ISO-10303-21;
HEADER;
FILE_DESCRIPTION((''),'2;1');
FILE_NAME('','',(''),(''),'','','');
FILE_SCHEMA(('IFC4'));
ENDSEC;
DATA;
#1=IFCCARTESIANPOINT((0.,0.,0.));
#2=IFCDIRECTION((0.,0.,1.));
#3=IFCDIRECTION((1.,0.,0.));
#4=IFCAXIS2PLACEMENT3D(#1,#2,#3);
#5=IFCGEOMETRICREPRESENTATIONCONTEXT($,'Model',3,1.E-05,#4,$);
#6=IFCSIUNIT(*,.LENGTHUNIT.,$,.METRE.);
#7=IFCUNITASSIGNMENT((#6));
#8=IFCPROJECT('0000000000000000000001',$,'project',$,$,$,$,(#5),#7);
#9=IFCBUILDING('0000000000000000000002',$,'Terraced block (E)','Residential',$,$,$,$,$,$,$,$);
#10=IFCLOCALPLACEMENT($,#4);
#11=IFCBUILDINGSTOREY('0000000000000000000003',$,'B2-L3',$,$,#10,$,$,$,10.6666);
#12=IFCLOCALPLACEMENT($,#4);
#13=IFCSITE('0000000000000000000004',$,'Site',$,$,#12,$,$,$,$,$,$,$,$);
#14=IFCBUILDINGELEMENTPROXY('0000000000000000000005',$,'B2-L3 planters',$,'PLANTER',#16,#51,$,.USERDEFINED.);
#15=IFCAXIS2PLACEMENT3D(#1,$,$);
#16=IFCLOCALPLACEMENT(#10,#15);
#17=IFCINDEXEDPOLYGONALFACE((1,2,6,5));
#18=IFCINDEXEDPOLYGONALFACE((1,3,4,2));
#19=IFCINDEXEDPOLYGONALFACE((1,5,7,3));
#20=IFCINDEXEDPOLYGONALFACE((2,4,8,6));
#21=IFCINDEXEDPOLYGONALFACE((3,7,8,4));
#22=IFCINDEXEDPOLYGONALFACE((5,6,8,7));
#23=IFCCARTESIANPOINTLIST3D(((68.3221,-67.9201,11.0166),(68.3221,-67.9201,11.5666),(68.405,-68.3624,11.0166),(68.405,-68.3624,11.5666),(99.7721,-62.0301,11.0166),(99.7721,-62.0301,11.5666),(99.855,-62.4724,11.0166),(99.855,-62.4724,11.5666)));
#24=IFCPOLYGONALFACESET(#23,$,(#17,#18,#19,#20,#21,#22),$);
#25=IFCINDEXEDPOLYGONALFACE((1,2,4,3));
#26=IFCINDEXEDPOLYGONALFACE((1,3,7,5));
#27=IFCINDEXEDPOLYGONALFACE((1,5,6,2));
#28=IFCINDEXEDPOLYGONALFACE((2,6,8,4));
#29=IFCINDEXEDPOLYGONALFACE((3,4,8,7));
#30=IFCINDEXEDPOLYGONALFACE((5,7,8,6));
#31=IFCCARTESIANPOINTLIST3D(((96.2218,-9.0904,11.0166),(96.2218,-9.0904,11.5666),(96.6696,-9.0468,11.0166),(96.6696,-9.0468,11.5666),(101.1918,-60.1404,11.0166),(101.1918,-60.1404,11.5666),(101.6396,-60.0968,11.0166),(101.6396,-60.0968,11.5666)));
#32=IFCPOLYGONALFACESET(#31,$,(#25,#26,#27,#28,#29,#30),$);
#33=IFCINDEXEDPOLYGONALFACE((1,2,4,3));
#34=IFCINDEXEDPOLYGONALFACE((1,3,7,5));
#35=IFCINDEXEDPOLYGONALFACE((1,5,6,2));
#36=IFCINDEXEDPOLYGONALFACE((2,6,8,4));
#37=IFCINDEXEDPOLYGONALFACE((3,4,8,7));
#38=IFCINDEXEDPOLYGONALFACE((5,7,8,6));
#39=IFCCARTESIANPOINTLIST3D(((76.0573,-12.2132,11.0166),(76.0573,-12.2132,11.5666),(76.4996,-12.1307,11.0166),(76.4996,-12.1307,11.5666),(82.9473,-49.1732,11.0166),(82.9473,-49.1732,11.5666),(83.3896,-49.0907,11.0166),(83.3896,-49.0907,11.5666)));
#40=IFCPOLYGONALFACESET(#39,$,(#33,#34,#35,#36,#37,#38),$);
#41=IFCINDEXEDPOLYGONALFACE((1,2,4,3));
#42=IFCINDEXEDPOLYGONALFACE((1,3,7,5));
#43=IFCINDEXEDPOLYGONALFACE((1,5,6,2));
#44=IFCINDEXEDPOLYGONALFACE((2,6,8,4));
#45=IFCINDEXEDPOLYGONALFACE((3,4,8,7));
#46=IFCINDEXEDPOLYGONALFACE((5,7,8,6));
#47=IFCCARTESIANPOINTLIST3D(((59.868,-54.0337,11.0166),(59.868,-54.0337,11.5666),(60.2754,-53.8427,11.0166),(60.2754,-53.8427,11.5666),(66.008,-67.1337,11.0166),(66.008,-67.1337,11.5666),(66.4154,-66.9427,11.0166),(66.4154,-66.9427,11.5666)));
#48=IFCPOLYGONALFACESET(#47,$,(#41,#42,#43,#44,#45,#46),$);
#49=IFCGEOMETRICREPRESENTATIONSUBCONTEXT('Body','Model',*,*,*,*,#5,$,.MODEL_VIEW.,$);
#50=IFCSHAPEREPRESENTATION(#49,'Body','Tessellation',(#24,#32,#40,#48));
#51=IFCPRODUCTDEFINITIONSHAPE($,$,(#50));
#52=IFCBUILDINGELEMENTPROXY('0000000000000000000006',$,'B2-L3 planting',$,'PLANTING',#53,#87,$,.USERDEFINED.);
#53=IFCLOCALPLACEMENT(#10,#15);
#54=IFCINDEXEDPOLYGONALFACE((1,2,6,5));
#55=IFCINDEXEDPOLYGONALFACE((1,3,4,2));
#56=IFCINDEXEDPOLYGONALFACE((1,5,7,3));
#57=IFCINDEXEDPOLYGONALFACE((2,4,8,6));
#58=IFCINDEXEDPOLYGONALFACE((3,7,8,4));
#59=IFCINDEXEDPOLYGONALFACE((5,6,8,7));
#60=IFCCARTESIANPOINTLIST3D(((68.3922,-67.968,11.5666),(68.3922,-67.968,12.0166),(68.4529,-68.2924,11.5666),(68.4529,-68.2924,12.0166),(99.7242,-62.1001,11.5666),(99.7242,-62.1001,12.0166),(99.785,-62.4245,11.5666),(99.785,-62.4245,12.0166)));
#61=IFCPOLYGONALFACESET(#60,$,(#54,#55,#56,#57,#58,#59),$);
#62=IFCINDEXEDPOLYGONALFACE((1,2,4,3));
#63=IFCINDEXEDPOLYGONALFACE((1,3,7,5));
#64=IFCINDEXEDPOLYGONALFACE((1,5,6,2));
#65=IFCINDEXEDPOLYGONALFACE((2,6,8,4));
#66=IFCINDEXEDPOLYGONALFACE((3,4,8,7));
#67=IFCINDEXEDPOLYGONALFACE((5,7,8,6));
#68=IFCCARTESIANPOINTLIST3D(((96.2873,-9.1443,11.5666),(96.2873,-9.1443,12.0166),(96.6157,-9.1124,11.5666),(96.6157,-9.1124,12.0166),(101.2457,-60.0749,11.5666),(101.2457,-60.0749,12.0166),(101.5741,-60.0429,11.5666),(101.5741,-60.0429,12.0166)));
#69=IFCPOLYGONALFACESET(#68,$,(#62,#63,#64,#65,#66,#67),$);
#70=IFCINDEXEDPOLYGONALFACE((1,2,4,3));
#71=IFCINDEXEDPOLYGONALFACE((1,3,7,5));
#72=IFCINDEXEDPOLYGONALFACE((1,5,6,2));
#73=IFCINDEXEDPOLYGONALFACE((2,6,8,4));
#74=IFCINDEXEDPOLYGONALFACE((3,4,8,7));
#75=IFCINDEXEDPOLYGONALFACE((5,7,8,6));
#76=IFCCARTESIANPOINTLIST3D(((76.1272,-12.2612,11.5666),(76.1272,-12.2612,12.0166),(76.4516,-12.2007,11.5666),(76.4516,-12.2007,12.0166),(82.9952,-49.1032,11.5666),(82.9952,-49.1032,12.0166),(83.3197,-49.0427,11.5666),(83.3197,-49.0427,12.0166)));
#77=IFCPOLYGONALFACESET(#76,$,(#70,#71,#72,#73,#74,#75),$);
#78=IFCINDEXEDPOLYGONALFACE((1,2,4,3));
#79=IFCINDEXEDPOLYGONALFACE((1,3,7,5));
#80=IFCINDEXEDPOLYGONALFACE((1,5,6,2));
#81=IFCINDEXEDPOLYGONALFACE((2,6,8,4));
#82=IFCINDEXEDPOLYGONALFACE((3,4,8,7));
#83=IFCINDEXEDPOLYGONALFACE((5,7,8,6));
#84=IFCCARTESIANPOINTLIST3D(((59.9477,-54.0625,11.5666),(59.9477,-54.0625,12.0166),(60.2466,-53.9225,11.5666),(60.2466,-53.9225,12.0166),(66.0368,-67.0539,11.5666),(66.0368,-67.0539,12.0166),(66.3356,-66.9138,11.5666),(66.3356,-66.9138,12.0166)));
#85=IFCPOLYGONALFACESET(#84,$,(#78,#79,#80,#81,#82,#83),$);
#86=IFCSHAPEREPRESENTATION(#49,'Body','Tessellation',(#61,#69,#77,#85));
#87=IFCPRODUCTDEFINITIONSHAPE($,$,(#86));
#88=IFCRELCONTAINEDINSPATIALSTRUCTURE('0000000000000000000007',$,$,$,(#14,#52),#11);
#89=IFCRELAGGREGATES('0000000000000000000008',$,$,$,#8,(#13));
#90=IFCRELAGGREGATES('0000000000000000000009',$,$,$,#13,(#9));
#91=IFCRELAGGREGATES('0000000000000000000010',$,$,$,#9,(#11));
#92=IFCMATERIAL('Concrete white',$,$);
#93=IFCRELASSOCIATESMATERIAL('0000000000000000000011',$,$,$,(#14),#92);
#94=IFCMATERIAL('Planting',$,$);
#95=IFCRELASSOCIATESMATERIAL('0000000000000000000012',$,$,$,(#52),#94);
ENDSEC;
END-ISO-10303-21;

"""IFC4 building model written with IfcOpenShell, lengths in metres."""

from ifc_helpers import new_model, si_unit, frame, origin_with_axes, place, context, subcontext, project, spatial, polyline, outline, extrude, material, element, save


model = new_model("IFC4")

# Units and contexts
model_context = context("Model", 3, precision=1e-05, world=origin_with_axes())
body_context = subcontext(model_context, "Body", "Model", "MODEL_VIEW")
ifc_project = project(units=[si_unit("LENGTHUNIT", "METRE")], contexts=[model_context])

# Site, building, storey
site_placement = place(None, origin_with_axes())
site = spatial("IfcSite", under=ifc_project, at=site_placement, Name="Site")
building = spatial("IfcBuilding", under=site, Name="Terraced block (E)", Description="Residential")
storey_placement = place(None, origin_with_axes())
storey = spatial("IfcBuildingStorey", under=building, at=storey_placement, Name="B2-L3", Elevation=10.6666)

# Shared definitions
ifc_material_1 = material(Name="Concrete white")

# Building element proxies
proxy_1_placement = place(storey_placement, origin_with_axes())
element("IfcBuildingElementProxy", 1, at=proxy_1_placement, inside=storey, material=ifc_material_1, Name="B2-L3 planters", ObjectType="PLANTER", PredefinedType="USERDEFINED", context=body_context, shape_type="SweptSolid", body=[
    extrude(outline(polyline([(68.405, -68.3624), (99.855, -62.4724), (99.7721, -62.0301), (68.3221, -67.9201), (68.405, -68.3624)])), frame((0.0, 0.0, 11.0166), z_axis=(0.0, 0.0, 1.0), x_axis=(1.0, 0.0, 0.0)), (0.0, 0.0, 1.0), 0.55),
    extrude(outline(polyline([(101.6396, -60.0968), (96.6696, -9.0468), (96.2218, -9.0904), (101.1918, -60.1404), (101.6396, -60.0968)])), frame((0.0, 0.0, 11.0166), z_axis=(0.0, 0.0, 1.0), x_axis=(1.0, 0.0, 0.0)), (0.0, 0.0, 1.0), 0.55),
    extrude(outline(polyline([(76.0573, -12.2132), (82.9473, -49.1732), (83.3896, -49.0907), (76.4996, -12.1307), (76.0573, -12.2132)])), frame((0.0, 0.0, 11.0166), z_axis=(0.0, 0.0, 1.0), x_axis=(1.0, 0.0, 0.0)), (0.0, 0.0, 1.0), 0.55),
    extrude(outline(polyline([(59.868, -54.0337), (66.008, -67.1337), (66.4154, -66.9427), (60.2754, -53.8427), (59.868, -54.0337)])), frame((0.0, 0.0, 11.0166), z_axis=(0.0, 0.0, 1.0), x_axis=(1.0, 0.0, 0.0)), (0.0, 0.0, 1.0), 0.55),
])
ifc_material_2 = material(Name="Planting")
proxy_2_placement = place(storey_placement, origin_with_axes())
element("IfcBuildingElementProxy", 2, at=proxy_2_placement, inside=storey, material=ifc_material_2, Name="B2-L3 planting", ObjectType="PLANTING", PredefinedType="USERDEFINED", context=body_context, shape_type="SweptSolid", body=[
    extrude(outline(polyline([(68.4529, -68.2924), (99.785, -62.4245), (99.7242, -62.1001), (68.3922, -67.968), (68.4529, -68.2924)])), frame((0.0, 0.0, 11.5666), z_axis=(0.0, 0.0, 1.0), x_axis=(1.0, 0.0, 0.0)), (0.0, 0.0, 1.0), 0.45),
    extrude(outline(polyline([(101.5741, -60.0429), (96.6157, -9.1124), (96.2873, -9.1443), (101.2457, -60.0749), (101.5741, -60.0429)])), frame((0.0, 0.0, 11.5666), z_axis=(0.0, 0.0, 1.0), x_axis=(1.0, 0.0, 0.0)), (0.0, 0.0, 1.0), 0.45),
    extrude(outline(polyline([(76.1272, -12.2612), (82.9952, -49.1032), (83.3197, -49.0427), (76.4516, -12.2007), (76.1272, -12.2612)])), frame((0.0, 0.0, 11.5666), z_axis=(0.0, 0.0, 1.0), x_axis=(1.0, 0.0, 0.0)), (0.0, 0.0, 1.0), 0.45),
    extrude(outline(polyline([(59.9477, -54.0625), (66.0368, -67.0539), (66.3356, -66.9138), (60.2466, -53.9225), (59.9477, -54.0625)])), frame((0.0, 0.0, 11.5666), z_axis=(0.0, 0.0, 1.0), x_axis=(1.0, 0.0, 0.0)), (0.0, 0.0, 1.0), 0.45),
])

save(model, "model.ifc")
